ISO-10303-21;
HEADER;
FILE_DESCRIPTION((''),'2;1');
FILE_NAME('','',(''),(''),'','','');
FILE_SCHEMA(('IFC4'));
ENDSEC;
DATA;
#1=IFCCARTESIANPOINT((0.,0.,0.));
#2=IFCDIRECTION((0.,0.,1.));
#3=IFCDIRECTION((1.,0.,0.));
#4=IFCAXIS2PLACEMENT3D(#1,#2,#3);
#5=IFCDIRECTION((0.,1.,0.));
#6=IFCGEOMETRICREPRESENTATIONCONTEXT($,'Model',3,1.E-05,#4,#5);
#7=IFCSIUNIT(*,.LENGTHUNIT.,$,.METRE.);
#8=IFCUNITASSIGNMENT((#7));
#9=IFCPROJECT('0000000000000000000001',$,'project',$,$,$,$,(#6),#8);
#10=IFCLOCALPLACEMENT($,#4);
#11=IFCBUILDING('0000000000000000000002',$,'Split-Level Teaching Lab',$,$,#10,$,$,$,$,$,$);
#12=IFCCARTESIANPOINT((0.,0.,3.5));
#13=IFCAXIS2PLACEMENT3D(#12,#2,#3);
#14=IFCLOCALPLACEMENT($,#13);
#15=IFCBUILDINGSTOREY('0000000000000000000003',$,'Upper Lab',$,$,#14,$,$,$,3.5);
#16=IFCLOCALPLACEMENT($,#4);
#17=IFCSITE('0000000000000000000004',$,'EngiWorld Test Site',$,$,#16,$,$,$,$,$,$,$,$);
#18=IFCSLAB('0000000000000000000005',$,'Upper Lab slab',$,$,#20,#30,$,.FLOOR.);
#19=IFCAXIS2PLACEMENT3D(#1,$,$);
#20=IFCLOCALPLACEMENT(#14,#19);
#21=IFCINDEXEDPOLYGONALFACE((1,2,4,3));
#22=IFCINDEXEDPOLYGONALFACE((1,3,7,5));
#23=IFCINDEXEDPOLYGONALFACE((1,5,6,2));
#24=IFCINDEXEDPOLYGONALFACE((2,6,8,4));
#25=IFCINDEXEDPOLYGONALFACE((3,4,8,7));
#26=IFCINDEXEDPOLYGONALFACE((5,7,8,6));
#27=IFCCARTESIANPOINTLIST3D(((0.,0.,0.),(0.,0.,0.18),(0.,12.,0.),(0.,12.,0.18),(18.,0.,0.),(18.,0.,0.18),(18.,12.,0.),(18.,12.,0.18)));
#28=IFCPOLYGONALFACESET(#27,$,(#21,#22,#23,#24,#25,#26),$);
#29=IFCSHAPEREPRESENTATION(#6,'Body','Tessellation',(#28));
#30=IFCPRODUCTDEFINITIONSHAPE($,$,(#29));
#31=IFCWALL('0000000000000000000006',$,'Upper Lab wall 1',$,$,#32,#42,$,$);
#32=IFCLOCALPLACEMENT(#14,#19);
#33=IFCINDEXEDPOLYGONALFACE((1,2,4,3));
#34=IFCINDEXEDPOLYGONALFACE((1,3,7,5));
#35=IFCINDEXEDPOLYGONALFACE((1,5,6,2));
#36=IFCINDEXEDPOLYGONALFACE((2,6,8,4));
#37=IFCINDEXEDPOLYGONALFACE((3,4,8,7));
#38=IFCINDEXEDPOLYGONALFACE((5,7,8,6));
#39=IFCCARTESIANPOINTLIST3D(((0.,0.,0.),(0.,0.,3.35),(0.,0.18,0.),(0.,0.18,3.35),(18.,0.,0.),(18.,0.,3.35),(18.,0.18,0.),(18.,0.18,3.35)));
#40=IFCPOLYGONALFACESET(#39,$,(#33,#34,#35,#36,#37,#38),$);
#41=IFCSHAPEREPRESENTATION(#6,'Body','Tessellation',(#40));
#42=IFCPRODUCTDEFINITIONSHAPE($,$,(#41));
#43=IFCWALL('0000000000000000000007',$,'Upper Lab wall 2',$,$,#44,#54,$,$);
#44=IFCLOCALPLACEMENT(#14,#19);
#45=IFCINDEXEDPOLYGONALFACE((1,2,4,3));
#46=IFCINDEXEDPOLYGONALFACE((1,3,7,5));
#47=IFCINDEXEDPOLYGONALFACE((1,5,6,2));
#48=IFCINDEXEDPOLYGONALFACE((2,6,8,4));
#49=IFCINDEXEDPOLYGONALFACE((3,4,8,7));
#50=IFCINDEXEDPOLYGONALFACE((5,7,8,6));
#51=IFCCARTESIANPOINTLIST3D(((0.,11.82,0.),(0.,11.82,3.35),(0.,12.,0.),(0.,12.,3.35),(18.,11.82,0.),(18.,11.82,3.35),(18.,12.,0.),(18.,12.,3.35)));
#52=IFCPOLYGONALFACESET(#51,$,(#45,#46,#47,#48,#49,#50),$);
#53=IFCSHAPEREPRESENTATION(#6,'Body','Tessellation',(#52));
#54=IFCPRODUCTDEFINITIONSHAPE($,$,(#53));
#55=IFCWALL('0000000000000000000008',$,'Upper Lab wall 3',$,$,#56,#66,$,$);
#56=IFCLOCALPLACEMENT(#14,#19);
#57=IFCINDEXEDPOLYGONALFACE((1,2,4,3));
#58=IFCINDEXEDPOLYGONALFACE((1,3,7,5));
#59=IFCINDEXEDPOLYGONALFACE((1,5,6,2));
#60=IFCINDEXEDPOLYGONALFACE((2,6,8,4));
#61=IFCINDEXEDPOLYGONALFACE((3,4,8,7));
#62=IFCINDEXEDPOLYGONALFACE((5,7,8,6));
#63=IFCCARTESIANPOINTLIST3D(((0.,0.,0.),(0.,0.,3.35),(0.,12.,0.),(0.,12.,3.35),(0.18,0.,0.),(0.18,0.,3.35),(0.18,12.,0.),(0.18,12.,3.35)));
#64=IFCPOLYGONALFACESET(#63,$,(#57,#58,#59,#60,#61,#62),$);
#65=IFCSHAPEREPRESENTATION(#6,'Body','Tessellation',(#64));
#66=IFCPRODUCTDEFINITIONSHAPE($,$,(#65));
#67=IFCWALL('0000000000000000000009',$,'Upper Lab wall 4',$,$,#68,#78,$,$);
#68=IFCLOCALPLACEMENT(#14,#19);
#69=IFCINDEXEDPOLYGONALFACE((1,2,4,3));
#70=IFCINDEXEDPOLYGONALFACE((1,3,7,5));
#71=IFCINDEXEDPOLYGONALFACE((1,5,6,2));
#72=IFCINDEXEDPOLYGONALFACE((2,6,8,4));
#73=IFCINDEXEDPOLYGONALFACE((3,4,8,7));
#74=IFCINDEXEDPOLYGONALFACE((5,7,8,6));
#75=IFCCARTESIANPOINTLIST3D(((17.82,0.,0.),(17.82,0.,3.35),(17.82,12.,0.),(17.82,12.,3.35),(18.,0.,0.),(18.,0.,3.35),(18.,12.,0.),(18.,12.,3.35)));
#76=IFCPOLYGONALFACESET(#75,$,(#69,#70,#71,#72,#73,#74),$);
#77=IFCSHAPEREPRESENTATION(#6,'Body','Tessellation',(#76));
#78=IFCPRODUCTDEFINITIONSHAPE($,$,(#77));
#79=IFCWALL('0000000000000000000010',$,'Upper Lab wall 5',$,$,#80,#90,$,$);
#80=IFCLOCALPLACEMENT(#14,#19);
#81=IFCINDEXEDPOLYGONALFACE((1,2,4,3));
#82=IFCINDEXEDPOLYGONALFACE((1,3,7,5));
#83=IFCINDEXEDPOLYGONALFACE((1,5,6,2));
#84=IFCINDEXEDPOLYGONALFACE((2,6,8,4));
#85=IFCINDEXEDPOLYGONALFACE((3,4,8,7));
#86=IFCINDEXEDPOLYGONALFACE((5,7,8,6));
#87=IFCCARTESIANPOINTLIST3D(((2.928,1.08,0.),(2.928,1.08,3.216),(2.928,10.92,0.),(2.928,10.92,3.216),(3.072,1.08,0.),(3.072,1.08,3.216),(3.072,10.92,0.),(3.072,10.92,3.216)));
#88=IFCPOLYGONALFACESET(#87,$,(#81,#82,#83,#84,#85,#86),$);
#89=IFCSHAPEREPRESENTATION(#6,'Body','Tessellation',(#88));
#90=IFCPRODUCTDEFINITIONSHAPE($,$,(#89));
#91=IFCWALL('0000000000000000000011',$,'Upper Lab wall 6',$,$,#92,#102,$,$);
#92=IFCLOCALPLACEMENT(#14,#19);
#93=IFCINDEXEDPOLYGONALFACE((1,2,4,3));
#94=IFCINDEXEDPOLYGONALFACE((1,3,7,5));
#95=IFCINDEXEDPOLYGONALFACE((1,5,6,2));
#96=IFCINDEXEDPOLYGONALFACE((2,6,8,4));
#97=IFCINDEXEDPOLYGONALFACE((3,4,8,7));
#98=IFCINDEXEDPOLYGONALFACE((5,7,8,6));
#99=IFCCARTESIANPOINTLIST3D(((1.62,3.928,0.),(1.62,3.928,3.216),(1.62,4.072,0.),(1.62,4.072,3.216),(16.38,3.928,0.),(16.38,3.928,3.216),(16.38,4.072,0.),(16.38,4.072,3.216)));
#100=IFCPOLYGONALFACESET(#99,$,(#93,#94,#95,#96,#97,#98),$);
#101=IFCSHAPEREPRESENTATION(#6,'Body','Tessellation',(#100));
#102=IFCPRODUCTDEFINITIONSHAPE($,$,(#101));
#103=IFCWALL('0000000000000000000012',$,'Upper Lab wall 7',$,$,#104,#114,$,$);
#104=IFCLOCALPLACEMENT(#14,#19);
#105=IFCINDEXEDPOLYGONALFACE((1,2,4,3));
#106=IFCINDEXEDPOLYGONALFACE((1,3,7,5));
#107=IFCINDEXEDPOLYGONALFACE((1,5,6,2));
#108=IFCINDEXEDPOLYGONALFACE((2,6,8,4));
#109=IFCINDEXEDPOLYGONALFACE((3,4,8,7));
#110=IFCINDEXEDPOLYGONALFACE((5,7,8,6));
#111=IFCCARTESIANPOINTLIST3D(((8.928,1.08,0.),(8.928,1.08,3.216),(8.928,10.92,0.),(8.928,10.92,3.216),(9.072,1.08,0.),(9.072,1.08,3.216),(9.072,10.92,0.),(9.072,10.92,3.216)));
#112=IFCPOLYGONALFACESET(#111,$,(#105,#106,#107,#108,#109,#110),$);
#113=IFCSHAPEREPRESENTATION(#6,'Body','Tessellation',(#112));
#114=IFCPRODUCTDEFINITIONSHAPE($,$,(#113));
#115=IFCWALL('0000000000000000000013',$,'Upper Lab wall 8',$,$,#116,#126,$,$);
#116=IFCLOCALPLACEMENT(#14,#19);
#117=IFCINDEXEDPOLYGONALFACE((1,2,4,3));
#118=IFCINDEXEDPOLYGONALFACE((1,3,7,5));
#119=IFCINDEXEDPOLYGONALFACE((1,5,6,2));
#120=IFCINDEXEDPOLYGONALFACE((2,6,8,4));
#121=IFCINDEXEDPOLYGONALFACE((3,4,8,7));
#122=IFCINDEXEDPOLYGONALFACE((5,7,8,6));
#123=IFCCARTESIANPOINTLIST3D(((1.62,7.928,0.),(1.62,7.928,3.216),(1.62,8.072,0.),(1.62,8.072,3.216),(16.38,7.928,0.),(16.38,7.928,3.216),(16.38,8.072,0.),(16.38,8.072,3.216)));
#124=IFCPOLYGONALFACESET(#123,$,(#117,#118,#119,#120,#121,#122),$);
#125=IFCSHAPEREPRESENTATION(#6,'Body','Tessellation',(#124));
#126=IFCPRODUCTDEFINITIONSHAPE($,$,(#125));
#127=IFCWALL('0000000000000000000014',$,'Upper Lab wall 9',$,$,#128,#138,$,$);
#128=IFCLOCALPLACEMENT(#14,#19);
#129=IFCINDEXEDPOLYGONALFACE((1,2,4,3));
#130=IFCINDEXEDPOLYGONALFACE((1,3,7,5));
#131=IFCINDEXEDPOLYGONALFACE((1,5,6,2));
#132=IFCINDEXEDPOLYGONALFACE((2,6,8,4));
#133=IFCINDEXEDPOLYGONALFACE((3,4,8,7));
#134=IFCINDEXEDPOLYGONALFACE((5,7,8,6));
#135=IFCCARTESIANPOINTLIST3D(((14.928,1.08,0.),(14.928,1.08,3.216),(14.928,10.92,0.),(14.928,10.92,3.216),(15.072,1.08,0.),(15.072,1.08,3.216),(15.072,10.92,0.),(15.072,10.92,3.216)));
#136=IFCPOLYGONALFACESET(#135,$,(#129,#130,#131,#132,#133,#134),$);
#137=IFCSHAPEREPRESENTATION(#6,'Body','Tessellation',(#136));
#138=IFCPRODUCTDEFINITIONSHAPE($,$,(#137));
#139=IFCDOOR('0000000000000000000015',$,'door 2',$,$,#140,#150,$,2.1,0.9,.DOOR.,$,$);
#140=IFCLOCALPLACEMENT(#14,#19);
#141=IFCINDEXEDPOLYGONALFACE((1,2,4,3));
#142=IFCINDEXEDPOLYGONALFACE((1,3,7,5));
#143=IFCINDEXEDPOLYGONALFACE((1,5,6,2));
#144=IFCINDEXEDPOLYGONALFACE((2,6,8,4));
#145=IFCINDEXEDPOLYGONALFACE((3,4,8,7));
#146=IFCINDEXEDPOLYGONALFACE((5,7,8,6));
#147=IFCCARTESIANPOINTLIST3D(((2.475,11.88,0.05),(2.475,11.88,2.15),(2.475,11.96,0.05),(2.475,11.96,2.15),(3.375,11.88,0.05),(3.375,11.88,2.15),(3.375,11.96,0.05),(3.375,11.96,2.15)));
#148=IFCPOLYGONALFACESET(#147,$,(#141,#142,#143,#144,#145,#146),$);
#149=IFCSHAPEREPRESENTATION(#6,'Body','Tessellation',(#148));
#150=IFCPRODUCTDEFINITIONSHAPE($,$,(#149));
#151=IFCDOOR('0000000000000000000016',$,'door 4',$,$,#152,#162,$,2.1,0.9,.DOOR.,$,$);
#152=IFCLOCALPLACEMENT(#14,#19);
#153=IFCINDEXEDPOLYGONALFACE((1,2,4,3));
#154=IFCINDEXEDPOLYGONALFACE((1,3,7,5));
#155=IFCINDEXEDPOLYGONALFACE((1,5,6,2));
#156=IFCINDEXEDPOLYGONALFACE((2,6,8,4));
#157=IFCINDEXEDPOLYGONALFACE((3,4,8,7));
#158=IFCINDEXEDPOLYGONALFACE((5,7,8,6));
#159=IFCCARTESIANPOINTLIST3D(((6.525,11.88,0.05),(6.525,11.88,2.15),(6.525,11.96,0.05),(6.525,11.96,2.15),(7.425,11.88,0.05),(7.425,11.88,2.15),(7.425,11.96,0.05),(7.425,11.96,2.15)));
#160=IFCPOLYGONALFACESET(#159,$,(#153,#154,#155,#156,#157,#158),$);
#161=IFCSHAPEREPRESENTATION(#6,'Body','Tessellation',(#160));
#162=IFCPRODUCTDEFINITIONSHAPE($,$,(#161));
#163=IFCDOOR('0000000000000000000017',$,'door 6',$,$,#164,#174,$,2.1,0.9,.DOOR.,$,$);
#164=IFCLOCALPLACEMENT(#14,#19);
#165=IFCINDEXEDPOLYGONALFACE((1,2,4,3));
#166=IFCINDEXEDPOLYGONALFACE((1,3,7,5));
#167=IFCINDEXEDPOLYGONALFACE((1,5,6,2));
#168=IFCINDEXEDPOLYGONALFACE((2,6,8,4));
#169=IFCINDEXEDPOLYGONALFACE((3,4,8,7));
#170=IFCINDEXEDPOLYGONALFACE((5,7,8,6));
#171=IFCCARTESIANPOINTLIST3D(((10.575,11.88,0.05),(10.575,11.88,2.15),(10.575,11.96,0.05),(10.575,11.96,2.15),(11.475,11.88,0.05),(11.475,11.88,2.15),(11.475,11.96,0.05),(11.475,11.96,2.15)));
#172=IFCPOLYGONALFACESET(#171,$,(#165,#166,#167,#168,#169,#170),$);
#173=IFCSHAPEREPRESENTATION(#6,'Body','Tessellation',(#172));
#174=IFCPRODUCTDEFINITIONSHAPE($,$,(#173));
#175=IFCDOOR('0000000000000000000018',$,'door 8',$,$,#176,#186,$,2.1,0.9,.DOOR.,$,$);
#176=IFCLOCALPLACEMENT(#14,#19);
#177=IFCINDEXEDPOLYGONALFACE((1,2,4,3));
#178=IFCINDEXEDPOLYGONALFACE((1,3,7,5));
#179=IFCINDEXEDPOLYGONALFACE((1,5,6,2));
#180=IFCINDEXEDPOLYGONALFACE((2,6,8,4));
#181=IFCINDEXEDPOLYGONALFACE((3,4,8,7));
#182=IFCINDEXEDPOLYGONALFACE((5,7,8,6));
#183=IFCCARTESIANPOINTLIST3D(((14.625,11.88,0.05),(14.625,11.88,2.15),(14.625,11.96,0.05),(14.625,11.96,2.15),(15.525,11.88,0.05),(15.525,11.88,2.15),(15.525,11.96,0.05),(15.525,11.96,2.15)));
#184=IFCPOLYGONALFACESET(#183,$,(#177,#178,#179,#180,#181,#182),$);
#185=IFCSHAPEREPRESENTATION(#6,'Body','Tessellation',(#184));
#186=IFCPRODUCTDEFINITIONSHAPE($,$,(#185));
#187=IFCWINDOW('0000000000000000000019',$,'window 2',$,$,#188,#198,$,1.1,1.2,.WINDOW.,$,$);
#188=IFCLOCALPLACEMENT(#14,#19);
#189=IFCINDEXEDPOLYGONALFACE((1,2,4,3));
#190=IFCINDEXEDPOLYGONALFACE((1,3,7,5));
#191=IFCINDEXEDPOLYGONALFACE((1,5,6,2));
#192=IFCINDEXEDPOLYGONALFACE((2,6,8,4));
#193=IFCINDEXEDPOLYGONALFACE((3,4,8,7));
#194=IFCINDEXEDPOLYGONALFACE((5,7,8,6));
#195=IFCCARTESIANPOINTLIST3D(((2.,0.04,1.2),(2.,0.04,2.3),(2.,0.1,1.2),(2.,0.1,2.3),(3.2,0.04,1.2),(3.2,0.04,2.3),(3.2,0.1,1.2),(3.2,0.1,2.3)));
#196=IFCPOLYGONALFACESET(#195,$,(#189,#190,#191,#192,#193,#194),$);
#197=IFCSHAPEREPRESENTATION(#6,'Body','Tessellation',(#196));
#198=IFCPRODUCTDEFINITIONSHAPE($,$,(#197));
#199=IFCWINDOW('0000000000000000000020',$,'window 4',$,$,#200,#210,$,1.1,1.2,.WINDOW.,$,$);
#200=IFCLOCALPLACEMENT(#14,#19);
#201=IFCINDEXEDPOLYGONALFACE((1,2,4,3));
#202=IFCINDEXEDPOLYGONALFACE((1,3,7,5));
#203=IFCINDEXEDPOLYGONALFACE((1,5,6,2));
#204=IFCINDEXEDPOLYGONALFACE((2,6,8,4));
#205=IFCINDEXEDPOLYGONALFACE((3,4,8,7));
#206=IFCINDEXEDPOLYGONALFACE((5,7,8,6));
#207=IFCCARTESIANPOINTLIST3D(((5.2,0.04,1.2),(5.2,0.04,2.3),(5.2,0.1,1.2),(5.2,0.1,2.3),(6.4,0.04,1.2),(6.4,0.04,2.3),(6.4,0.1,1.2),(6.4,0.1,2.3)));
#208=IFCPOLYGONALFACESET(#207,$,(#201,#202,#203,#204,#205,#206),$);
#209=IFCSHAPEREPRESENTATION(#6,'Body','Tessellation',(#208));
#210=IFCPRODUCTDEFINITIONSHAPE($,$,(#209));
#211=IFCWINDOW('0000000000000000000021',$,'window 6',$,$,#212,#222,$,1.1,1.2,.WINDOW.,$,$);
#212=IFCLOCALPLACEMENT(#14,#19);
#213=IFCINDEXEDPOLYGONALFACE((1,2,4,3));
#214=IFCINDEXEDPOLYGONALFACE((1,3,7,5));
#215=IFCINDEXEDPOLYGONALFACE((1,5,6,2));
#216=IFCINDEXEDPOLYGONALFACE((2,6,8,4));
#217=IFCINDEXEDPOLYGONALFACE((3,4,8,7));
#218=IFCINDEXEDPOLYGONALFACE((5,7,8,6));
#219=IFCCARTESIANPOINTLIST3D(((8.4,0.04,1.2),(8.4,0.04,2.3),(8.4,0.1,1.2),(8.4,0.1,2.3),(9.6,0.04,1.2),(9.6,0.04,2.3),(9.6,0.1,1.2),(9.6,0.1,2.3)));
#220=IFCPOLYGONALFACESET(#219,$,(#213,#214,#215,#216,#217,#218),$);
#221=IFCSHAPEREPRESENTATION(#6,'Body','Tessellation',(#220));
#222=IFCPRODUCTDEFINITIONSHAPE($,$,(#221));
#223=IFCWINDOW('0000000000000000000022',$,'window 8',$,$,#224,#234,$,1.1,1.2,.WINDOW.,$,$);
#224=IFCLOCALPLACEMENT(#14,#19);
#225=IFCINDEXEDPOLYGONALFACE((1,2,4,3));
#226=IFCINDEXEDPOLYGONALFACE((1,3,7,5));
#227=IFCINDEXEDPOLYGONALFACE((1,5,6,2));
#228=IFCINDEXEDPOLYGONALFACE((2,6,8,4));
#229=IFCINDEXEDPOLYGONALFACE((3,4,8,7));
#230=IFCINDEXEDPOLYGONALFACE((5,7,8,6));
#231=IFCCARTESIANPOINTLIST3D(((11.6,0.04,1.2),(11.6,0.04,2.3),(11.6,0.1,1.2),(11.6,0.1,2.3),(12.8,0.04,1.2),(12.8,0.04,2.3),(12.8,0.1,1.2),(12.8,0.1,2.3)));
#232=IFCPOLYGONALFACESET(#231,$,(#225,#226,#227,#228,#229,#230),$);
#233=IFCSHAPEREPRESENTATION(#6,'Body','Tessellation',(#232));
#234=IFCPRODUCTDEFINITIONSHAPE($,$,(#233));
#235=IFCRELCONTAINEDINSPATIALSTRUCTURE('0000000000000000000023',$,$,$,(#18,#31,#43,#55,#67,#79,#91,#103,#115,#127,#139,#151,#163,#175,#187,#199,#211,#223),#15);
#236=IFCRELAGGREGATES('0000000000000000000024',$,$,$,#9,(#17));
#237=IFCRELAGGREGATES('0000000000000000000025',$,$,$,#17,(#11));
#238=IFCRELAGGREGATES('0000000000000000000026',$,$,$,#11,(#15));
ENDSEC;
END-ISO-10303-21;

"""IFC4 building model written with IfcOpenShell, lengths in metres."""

from ifc_helpers import new_model, si_unit, direction, frame, origin_with_axes, origin_2d_with_axis, place, context, project, spatial, rectangle, extrude, element, save


model = new_model("IFC4")

# Units and contexts
model_context = context("Model", 3, precision=1e-05, world=origin_with_axes(), true_north=direction((0.0, 1.0, 0.0)))
ifc_project = project(units=[si_unit("LENGTHUNIT", "METRE")], contexts=[model_context])

# Site, building, storey
site_placement = place(None, origin_with_axes())
site = spatial("IfcSite", under=ifc_project, at=site_placement, Name="EngiWorld Test Site")
building_placement = place(None, origin_with_axes())
building = spatial("IfcBuilding", under=site, at=building_placement, Name="Split-Level Teaching Lab")
storey_placement = place(None, frame((0.0, 0.0, 3.5), z_axis=(0.0, 0.0, 1.0), x_axis=(1.0, 0.0, 0.0)))
storey = spatial("IfcBuildingStorey", under=building, at=storey_placement, Name="Upper Lab", Elevation=3.5)

# Slab
slab_placement = place(None, frame((9.0, 6.0, 3.5), z_axis=(0.0, 0.0, 1.0), x_axis=(1.0, 0.0, 0.0)))
element("IfcSlab", 1, at=slab_placement, inside=storey, Name="Upper Lab slab", PredefinedType="FLOOR", context=model_context, shape_type="SweptSolid", body=[
    extrude(rectangle(XDim=18.0, YDim=12.0, at=origin_2d_with_axis()), origin_with_axes(), (0.0, 0.0, 1.0), 0.18),
])

# Walls
for number, where, z_axis, x_axis, name in (
    (2, (9.0, 0.09, 3.5), (0.0, 0.0, 1.0), (1.0, 0.0, 0.0), "Upper Lab wall 1"),
    (3, (9.0, 11.91, 3.5), (0.0, 0.0, 1.0), (1.0, 0.0, 0.0), "Upper Lab wall 2"),
):
    element("IfcWall", number, at=place(None, frame(where, z_axis=z_axis, x_axis=x_axis)), inside=storey, Name=name, context=model_context, shape_type="SweptSolid", body=[
        extrude(rectangle(XDim=18.0, YDim=0.18, at=origin_2d_with_axis()), origin_with_axes(), (0.0, 0.0, 1.0), 3.35),
    ])
for number, where, z_axis, x_axis, name in (
    (4, (0.09, 6.0, 3.5), (0.0, 0.0, 1.0), (1.0, 0.0, 0.0), "Upper Lab wall 3"),
    (5, (17.91, 6.0, 3.5), (0.0, 0.0, 1.0), (1.0, 0.0, 0.0), "Upper Lab wall 4"),
):
    element("IfcWall", number, at=place(None, frame(where, z_axis=z_axis, x_axis=x_axis)), inside=storey, Name=name, context=model_context, shape_type="SweptSolid", body=[
        extrude(rectangle(XDim=0.18, YDim=12.0, at=origin_2d_with_axis()), origin_with_axes(), (0.0, 0.0, 1.0), 3.35),
    ])
wall_1_placement = place(None, frame((3.0, 6.0, 3.5), z_axis=(0.0, 0.0, 1.0), x_axis=(1.0, 0.0, 0.0)))
element("IfcWall", 6, at=wall_1_placement, inside=storey, Name="Upper Lab wall 5", context=model_context, shape_type="SweptSolid", body=[
    extrude(rectangle(XDim=0.144, YDim=9.84, at=origin_2d_with_axis()), origin_with_axes(), (0.0, 0.0, 1.0), 3.216),
])
wall_2_placement = place(None, frame((9.0, 4.0, 3.5), z_axis=(0.0, 0.0, 1.0), x_axis=(1.0, 0.0, 0.0)))
element("IfcWall", 7, at=wall_2_placement, inside=storey, Name="Upper Lab wall 6", context=model_context, shape_type="SweptSolid", body=[
    extrude(rectangle(XDim=14.76, YDim=0.144, at=origin_2d_with_axis()), origin_with_axes(), (0.0, 0.0, 1.0), 3.216),
])
wall_3_placement = place(None, frame((9.0, 6.0, 3.5), z_axis=(0.0, 0.0, 1.0), x_axis=(1.0, 0.0, 0.0)))
element("IfcWall", 8, at=wall_3_placement, inside=storey, Name="Upper Lab wall 7", context=model_context, shape_type="SweptSolid", body=[
    extrude(rectangle(XDim=0.144, YDim=9.84, at=origin_2d_with_axis()), origin_with_axes(), (0.0, 0.0, 1.0), 3.216),
])
wall_4_placement = place(None, frame((9.0, 8.0, 3.5), z_axis=(0.0, 0.0, 1.0), x_axis=(1.0, 0.0, 0.0)))
element("IfcWall", 9, at=wall_4_placement, inside=storey, Name="Upper Lab wall 8", context=model_context, shape_type="SweptSolid", body=[
    extrude(rectangle(XDim=14.76, YDim=0.144, at=origin_2d_with_axis()), origin_with_axes(), (0.0, 0.0, 1.0), 3.216),
])
wall_5_placement = place(None, frame((15.0, 6.0, 3.5), z_axis=(0.0, 0.0, 1.0), x_axis=(1.0, 0.0, 0.0)))
element("IfcWall", 10, at=wall_5_placement, inside=storey, Name="Upper Lab wall 9", context=model_context, shape_type="SweptSolid", body=[
    extrude(rectangle(XDim=0.144, YDim=9.84, at=origin_2d_with_axis()), origin_with_axes(), (0.0, 0.0, 1.0), 3.216),
])

# Doors
for number, where, z_axis, x_axis, name in (
    (11, (2.925, 11.92, 3.55), (0.0, 0.0, 1.0), (1.0, 0.0, 0.0), "door 2"),
    (12, (6.975, 11.92, 3.55), (0.0, 0.0, 1.0), (1.0, 0.0, 0.0), "door 4"),
    (13, (11.025, 11.92, 3.55), (0.0, 0.0, 1.0), (1.0, 0.0, 0.0), "door 6"),
    (14, (15.075, 11.92, 3.55), (0.0, 0.0, 1.0), (1.0, 0.0, 0.0), "door 8"),
):
    element("IfcDoor", number, at=place(None, frame(where, z_axis=z_axis, x_axis=x_axis)), inside=storey, Name=name, OverallHeight=2.1, OverallWidth=0.9, PredefinedType="DOOR", context=model_context, shape_type="SweptSolid", body=[
        extrude(rectangle(XDim=0.9, YDim=0.08, at=origin_2d_with_axis()), origin_with_axes(), (0.0, 0.0, 1.0), 2.1),
    ])

# Windows
for number, where, z_axis, x_axis, name in (
    (15, (2.6, 0.07, 4.7), (0.0, 0.0, 1.0), (1.0, 0.0, 0.0), "window 2"),
    (16, (5.8, 0.07, 4.7), (0.0, 0.0, 1.0), (1.0, 0.0, 0.0), "window 4"),
    (17, (9.0, 0.07, 4.7), (0.0, 0.0, 1.0), (1.0, 0.0, 0.0), "window 6"),
    (18, (12.2, 0.07, 4.7), (0.0, 0.0, 1.0), (1.0, 0.0, 0.0), "window 8"),
):
    element("IfcWindow", number, at=place(None, frame(where, z_axis=z_axis, x_axis=x_axis)), inside=storey, Name=name, OverallHeight=1.1, OverallWidth=1.2, PredefinedType="WINDOW", context=model_context, shape_type="SweptSolid", body=[
        extrude(rectangle(XDim=1.2, YDim=0.06, at=origin_2d_with_axis()), origin_with_axes(), (0.0, 0.0, 1.0), 1.1),
    ])

save(model, "model.ifc")
